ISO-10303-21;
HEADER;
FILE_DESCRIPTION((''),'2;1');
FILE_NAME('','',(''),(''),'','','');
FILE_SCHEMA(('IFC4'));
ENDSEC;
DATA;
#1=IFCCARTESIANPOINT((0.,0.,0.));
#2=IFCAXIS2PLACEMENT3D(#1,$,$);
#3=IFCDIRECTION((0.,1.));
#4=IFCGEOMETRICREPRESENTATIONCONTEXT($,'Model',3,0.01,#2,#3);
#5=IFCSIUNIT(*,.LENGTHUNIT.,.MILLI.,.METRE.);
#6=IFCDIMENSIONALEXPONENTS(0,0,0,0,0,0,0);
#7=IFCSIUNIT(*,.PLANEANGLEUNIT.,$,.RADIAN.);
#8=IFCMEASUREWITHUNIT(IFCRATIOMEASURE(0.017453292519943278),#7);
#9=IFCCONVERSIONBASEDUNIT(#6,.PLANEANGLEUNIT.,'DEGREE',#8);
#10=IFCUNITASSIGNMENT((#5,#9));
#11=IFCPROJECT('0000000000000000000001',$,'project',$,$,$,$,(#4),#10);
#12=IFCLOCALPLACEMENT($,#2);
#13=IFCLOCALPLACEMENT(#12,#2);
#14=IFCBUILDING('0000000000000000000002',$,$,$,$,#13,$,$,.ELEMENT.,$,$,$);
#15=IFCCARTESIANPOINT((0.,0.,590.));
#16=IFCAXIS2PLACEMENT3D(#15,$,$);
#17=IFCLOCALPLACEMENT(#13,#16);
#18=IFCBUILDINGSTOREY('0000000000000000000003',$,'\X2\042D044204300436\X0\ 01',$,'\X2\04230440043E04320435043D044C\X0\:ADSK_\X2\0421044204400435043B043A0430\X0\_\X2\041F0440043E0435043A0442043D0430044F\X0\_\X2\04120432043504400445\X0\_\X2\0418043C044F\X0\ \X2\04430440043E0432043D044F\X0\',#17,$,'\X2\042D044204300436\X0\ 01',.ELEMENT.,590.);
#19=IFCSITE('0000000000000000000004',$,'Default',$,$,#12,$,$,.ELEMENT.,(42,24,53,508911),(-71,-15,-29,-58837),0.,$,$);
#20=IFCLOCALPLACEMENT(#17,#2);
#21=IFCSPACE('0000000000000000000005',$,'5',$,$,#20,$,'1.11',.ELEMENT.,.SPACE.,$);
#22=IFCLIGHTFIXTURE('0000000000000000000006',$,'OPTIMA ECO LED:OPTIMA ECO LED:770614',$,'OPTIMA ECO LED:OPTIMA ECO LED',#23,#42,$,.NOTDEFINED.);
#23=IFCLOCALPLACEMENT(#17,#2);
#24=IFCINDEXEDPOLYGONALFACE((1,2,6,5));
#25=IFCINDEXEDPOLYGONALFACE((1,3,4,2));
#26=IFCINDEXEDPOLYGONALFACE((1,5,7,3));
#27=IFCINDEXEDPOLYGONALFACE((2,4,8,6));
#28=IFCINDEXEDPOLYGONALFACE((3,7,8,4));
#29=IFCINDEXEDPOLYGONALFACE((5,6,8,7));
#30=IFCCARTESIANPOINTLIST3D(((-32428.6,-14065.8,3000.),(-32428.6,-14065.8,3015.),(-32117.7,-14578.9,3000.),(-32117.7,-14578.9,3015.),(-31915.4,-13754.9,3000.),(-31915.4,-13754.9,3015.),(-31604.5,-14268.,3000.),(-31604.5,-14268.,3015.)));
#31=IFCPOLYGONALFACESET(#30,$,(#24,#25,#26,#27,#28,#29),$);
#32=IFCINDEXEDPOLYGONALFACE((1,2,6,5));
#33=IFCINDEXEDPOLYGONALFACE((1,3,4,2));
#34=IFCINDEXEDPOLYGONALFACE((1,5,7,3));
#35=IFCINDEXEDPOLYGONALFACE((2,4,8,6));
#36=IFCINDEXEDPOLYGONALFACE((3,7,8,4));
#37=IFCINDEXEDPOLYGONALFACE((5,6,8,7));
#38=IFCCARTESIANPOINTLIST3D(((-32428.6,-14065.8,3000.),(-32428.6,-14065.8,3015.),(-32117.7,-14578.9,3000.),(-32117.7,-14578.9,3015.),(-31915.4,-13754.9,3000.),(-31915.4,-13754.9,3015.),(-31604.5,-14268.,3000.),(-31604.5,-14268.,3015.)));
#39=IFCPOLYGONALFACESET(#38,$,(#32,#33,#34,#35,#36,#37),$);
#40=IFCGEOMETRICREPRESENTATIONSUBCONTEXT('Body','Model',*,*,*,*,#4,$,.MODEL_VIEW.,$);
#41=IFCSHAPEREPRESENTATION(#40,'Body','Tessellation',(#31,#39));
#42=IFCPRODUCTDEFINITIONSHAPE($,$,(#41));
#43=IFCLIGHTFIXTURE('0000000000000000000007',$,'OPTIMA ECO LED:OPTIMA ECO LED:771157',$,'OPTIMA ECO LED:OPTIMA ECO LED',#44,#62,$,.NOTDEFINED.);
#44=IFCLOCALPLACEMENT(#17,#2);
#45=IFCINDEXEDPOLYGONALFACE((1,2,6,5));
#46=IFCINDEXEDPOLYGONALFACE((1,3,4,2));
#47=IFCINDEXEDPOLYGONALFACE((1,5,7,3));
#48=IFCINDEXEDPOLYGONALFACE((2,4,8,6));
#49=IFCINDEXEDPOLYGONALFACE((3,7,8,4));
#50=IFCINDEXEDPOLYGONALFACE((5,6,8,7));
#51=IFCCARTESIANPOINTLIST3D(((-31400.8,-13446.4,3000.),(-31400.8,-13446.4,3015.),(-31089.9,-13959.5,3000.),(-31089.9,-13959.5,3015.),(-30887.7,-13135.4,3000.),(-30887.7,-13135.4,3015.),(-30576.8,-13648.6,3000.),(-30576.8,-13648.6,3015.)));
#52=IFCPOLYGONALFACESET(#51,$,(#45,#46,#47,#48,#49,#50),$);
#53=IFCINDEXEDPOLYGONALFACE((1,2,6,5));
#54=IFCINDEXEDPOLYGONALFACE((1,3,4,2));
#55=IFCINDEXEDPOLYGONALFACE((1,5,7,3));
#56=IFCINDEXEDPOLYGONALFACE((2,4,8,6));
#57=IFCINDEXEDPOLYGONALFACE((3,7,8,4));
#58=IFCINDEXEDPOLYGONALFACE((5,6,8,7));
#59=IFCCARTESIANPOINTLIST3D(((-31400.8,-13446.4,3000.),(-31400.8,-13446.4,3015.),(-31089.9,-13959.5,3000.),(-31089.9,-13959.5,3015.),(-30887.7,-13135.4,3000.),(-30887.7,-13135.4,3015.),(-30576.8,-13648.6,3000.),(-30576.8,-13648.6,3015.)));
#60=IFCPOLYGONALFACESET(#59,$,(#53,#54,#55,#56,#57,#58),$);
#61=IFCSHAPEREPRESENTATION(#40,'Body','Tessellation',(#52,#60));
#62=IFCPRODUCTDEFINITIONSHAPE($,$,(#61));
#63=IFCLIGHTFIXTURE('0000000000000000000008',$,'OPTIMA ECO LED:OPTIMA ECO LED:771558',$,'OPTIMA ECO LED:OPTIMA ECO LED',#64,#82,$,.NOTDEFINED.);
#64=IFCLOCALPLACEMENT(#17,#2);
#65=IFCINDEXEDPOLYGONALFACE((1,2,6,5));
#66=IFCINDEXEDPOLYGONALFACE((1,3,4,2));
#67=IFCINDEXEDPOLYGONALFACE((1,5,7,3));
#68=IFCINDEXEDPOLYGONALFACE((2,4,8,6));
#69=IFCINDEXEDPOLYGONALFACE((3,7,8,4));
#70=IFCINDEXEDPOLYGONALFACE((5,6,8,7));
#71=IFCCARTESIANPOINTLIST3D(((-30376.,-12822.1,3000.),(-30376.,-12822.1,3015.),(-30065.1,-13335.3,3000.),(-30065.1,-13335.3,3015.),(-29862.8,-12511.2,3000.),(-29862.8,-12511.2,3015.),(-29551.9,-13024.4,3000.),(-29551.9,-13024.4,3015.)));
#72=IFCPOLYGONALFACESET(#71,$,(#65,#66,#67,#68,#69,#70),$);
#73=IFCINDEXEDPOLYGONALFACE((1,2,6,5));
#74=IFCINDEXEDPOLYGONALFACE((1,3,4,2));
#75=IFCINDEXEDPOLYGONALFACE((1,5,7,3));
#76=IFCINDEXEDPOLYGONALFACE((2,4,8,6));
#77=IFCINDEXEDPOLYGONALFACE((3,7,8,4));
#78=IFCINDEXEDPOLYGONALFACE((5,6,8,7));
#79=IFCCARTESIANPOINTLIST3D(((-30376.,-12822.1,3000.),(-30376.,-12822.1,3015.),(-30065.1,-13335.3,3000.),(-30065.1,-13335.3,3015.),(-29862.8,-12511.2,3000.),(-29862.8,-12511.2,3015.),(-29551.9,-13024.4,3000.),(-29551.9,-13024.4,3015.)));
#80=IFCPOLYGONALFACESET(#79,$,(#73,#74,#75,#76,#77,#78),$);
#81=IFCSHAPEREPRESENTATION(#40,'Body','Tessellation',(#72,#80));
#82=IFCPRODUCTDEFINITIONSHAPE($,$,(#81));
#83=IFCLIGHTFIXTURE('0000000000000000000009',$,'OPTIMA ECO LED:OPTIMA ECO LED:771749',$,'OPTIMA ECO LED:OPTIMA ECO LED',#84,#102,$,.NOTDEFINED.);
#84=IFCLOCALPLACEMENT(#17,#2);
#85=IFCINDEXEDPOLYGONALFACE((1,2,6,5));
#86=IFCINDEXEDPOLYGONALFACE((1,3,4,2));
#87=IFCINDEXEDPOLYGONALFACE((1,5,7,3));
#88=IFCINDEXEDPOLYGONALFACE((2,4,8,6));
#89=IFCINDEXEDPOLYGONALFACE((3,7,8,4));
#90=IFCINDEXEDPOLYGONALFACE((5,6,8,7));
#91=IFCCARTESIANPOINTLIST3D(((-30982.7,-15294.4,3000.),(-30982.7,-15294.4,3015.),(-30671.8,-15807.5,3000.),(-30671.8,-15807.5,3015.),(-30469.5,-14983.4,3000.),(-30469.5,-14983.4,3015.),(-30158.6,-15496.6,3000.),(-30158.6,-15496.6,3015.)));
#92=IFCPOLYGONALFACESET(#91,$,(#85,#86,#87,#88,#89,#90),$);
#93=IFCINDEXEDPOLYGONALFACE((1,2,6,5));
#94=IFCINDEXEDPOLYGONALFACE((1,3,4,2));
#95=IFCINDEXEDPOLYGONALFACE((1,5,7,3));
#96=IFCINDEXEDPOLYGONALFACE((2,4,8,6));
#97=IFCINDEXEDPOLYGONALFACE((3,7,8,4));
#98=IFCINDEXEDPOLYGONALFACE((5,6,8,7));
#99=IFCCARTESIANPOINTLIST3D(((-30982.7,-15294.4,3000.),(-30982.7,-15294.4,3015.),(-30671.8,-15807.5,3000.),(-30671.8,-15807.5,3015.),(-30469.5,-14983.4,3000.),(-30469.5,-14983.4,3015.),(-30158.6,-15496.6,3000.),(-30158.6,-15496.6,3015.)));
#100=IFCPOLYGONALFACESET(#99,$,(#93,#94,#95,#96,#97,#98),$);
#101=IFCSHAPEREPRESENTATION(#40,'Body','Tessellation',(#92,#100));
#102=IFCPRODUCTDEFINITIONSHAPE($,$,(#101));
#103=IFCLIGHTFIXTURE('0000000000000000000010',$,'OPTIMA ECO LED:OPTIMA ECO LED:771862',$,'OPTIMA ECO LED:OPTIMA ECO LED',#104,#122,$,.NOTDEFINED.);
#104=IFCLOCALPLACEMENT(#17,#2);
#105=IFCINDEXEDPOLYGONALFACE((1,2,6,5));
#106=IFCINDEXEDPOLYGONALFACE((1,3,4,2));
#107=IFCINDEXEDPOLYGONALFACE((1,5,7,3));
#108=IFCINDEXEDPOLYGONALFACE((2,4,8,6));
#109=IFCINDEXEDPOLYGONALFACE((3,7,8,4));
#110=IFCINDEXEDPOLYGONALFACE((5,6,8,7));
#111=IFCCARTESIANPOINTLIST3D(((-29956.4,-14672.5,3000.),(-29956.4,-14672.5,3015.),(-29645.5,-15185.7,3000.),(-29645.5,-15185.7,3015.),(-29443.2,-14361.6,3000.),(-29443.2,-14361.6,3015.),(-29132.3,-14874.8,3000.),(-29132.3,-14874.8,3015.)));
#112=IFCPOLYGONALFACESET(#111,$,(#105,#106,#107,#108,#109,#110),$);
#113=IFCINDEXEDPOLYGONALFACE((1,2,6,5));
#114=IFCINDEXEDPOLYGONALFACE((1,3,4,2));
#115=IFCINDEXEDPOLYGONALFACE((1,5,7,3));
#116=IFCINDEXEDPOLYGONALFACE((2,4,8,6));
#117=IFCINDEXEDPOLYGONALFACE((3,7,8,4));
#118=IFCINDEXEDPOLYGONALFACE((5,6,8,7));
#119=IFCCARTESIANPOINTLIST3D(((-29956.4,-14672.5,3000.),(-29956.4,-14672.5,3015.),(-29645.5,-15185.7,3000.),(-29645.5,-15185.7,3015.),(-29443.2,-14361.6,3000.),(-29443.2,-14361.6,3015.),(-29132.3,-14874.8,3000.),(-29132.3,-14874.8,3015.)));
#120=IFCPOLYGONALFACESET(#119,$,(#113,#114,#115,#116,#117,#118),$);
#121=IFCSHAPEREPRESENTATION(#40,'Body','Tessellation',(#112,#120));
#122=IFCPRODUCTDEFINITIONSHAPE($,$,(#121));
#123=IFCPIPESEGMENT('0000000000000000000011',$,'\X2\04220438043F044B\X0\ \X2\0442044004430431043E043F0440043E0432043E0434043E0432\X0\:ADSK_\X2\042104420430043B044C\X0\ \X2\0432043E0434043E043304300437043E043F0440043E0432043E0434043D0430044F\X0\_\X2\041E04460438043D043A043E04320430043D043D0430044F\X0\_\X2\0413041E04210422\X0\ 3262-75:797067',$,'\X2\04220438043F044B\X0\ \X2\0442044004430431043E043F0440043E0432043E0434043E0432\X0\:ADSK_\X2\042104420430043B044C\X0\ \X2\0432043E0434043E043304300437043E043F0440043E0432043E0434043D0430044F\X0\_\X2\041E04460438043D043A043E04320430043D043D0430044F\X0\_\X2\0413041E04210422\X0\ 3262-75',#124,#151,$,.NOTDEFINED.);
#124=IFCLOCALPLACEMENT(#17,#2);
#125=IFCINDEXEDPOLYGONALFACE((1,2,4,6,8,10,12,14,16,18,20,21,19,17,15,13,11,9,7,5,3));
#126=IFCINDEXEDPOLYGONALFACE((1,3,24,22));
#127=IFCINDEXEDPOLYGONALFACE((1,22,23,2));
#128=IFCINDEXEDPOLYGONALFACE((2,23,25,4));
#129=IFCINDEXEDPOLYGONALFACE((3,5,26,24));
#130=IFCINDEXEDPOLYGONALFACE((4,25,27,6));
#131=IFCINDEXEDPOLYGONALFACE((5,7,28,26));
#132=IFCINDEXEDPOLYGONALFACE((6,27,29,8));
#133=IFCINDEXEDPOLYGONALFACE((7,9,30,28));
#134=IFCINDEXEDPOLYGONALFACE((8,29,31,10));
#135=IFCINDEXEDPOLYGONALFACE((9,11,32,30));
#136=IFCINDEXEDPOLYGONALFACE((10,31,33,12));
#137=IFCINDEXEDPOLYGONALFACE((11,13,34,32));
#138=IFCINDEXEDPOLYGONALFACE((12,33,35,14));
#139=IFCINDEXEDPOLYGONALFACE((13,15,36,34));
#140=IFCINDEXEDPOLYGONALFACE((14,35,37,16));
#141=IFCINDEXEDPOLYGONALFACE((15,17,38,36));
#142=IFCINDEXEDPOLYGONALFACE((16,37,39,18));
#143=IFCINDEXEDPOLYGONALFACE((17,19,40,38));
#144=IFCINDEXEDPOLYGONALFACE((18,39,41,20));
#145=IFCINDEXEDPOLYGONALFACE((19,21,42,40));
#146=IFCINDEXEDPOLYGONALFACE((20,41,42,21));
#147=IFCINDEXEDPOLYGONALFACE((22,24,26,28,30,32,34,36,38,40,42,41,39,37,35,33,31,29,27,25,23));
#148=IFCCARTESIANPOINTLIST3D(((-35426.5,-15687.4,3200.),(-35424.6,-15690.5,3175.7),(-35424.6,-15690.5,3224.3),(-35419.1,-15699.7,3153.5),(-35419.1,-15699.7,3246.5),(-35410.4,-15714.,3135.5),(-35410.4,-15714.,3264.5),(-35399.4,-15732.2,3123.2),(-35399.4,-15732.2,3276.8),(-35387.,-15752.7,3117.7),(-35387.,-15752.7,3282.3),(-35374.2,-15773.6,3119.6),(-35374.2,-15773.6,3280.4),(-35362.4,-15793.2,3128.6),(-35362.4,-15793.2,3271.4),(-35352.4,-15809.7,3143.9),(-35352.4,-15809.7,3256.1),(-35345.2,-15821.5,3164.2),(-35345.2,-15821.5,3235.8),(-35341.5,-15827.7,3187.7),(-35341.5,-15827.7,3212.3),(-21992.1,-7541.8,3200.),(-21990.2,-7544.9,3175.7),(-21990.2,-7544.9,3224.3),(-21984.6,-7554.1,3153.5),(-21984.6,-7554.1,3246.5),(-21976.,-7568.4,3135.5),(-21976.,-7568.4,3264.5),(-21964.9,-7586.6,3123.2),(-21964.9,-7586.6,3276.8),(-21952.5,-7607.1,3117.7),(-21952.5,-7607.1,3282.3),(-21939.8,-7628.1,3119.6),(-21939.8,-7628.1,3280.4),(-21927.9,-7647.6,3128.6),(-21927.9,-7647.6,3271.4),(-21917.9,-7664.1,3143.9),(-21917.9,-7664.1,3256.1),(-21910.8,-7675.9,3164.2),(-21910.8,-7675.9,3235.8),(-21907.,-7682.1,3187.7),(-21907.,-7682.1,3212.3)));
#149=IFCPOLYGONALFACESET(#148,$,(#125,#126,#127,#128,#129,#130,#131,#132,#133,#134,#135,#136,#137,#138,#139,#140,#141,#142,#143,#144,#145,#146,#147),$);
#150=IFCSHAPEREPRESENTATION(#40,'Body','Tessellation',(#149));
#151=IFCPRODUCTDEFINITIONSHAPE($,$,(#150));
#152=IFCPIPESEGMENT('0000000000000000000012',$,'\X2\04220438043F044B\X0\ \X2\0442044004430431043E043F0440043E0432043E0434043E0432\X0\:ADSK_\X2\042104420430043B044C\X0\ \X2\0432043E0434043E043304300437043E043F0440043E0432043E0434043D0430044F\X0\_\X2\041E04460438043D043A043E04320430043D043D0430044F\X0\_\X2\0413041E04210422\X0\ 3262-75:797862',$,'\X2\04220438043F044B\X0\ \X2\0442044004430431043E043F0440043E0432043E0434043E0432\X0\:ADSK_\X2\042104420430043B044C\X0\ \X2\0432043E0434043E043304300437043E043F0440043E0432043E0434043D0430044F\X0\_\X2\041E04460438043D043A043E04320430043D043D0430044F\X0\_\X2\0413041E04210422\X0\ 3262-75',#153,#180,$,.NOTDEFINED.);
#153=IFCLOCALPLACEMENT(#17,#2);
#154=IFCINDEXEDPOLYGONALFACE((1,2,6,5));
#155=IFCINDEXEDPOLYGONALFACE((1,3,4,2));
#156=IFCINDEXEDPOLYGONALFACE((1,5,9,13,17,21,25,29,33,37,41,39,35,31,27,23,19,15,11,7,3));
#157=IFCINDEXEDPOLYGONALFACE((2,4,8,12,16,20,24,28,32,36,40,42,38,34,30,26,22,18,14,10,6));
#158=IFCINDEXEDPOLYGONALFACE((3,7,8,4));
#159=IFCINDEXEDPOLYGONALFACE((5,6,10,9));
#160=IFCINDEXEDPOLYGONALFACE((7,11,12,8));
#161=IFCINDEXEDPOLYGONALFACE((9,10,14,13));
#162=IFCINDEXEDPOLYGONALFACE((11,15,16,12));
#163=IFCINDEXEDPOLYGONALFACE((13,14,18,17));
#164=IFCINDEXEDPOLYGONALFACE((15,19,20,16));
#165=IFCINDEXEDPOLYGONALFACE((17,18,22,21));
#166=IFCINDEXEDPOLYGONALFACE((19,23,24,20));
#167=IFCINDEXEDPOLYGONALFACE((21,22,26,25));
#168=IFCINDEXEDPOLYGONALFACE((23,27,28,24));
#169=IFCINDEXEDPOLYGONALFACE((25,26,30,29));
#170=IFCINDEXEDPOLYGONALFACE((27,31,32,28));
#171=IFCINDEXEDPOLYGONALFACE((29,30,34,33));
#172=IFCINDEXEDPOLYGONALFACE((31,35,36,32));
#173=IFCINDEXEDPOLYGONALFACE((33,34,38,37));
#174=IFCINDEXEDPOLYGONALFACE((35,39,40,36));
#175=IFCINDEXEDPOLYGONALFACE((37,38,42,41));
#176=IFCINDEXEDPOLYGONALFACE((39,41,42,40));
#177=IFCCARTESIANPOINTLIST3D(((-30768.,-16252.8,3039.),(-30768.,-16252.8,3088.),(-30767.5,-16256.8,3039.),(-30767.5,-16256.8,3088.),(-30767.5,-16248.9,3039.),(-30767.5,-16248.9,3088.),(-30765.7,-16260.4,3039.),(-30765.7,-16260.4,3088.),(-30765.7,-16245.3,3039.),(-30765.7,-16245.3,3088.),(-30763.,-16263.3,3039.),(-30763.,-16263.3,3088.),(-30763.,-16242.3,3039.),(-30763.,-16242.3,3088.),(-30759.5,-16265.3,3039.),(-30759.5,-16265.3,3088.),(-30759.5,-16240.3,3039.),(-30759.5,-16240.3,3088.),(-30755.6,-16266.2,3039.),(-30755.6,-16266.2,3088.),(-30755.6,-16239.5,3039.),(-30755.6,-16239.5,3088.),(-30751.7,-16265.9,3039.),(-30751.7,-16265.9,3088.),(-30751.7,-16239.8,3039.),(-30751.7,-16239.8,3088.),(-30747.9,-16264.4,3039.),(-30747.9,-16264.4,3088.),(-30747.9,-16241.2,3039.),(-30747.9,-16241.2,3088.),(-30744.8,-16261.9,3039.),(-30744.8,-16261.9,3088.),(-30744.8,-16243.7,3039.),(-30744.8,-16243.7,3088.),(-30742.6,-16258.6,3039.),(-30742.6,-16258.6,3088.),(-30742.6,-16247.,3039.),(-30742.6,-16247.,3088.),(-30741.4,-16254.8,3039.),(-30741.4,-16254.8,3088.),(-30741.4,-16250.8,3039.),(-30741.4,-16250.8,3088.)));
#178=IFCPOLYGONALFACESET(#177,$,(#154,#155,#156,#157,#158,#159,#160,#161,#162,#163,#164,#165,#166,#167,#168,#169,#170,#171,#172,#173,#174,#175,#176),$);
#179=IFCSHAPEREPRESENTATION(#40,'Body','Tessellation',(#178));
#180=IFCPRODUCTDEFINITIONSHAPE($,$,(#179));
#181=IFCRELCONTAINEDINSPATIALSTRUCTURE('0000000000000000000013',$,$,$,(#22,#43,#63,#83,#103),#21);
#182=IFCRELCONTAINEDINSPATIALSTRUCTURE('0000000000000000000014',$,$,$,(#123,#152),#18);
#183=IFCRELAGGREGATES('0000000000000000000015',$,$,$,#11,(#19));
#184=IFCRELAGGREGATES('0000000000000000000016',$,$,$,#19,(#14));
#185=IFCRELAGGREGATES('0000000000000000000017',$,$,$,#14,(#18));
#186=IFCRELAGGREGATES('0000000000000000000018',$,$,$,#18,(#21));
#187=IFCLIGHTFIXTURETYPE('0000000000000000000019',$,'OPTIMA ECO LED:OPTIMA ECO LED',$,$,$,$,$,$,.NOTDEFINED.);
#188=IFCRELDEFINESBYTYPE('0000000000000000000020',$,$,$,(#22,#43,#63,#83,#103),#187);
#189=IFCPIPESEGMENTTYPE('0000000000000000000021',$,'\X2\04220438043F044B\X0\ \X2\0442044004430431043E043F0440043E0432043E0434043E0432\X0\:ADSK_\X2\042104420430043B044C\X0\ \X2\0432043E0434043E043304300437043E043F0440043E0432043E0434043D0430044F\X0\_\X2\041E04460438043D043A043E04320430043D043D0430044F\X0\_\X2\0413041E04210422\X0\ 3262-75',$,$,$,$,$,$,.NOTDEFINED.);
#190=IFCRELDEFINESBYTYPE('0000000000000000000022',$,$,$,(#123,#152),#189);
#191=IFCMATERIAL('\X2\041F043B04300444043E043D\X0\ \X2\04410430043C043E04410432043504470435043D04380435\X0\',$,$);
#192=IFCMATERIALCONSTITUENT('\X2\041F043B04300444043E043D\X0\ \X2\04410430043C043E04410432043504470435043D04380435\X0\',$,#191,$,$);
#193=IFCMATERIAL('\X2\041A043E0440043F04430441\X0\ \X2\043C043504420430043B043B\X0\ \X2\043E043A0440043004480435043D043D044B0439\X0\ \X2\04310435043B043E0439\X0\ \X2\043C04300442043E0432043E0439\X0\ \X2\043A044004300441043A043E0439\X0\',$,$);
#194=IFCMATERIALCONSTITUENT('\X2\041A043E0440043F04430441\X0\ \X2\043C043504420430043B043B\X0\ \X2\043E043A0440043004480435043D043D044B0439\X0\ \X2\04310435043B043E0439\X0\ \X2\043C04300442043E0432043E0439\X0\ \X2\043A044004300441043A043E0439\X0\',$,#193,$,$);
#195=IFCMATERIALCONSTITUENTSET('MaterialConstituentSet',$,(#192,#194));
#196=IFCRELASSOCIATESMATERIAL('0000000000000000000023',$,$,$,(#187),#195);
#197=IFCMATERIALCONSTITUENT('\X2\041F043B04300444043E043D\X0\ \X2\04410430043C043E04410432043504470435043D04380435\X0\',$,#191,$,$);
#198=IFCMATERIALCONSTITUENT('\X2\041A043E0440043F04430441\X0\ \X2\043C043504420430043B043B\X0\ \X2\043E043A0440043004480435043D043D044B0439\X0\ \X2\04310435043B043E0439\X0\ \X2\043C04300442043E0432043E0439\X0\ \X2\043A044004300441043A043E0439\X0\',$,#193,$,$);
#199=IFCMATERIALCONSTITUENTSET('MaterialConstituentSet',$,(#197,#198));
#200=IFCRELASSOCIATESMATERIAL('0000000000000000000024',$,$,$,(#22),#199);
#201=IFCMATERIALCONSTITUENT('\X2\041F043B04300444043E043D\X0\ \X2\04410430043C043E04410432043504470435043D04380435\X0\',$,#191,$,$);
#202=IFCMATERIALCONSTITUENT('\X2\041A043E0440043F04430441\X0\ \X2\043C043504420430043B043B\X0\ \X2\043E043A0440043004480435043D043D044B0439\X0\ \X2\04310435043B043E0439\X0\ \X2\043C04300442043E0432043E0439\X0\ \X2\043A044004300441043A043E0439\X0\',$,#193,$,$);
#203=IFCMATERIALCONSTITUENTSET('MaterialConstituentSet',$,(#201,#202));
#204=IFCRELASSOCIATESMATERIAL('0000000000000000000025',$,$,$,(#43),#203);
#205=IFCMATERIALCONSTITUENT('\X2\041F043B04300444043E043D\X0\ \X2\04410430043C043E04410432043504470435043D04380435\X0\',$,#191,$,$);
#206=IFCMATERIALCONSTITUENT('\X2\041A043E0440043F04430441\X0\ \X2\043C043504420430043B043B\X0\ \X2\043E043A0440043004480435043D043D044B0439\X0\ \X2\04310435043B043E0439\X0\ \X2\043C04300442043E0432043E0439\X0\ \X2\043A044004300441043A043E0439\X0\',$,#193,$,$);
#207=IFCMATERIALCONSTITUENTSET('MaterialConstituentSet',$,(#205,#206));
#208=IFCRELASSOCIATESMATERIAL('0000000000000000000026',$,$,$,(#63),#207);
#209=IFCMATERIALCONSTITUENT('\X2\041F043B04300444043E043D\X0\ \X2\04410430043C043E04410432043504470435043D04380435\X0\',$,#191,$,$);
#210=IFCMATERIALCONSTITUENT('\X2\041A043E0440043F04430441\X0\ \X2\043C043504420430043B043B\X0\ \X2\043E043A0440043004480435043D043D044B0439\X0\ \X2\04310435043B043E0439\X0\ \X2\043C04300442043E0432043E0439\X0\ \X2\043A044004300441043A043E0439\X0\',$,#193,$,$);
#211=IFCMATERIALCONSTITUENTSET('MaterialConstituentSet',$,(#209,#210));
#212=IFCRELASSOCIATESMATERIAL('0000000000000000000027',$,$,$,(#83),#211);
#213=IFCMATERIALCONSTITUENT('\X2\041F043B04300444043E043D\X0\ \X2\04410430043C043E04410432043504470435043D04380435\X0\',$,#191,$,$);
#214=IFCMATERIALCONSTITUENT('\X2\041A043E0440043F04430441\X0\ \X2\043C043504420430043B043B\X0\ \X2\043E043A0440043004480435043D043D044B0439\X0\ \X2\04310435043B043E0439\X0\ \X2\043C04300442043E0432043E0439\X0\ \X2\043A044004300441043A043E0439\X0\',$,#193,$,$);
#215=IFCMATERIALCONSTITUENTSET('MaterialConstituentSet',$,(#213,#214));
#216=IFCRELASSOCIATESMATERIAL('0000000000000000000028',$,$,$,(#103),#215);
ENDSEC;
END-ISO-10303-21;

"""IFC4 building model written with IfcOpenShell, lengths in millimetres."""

from ifc_helpers import new_model, entity, si_unit, converted_unit, direction, frame, frame_2d, origin, origin_2d_with_axis, place, context, subcontext, project, spatial, rectangle, circle, extrude, source, transform, mapped, material, constituent, constituent_set, type_object, type_shapes, element, save


model = new_model("IFC4")

# Units and contexts
model_context = context("Model", 3, precision=0.01, world=origin(), true_north=direction((0.0, 1.0)))
body_context = subcontext(model_context, "Body", "Model", "MODEL_VIEW")
ifc_project = project(units=[si_unit("LENGTHUNIT", "METRE", prefix="MILLI"), converted_unit("PLANEANGLEUNIT", "DEGREE", entity("IfcRatioMeasure", 0.017453292519943278), si_unit("PLANEANGLEUNIT", "RADIAN"), dimensions=[0, 0, 0, 0, 0, 0, 0])], contexts=[model_context])

# Site, building, storey
site_placement = place(None, origin())
site = spatial("IfcSite", under=ifc_project, at=site_placement, Name="Default", CompositionType="ELEMENT", RefLatitude=(42, 24, 53, 508911), RefLongitude=(-71, -15, -29, -58837), RefElevation=0.0)
building_placement = place(site_placement, origin())
building = spatial("IfcBuilding", under=site, at=building_placement, CompositionType="ELEMENT")
storey_placement = place(building_placement, frame((0.0, 0.0, 590.0)))
storey = spatial("IfcBuildingStorey", under=building, at=storey_placement, Name="Этаж 01", ObjectType="Уровень:ADSK_Стрелка_Проектная_Вверх_Имя уровня", LongName="Этаж 01", CompositionType="ELEMENT", Elevation=590.0)

# Shared definitions
space_1_placement = place(storey_placement, origin())
space_1 = spatial("IfcSpace", under=storey, at=space_1_placement, Name="5", LongName="1.11", CompositionType="ELEMENT", PredefinedType="SPACE")

# Light fixtures
ifc_material_1 = material(Name="Плафон самосвечение")
ifc_constituent_1 = constituent(ifc_material_1, Name="Плафон самосвечение")
ifc_material_2 = material(Name="Корпус металл окрашенный белой матовой краской")
ifc_constituent_2 = constituent(ifc_material_2, Name="Корпус металл окрашенный белой матовой краской")
ifc_constituent_set_1 = constituent_set(constituents=[ifc_constituent_1, ifc_constituent_2], Name="MaterialConstituentSet")
ifc_constituent_3 = constituent(ifc_material_1, Name="Плафон самосвечение")
ifc_constituent_4 = constituent(ifc_material_2, Name="Корпус металл окрашенный белой матовой краской")
ifc_constituent_set_2 = constituent_set(constituents=[ifc_constituent_3, ifc_constituent_4], Name="MaterialConstituentSet")
light_fixture_type = type_object("IfcLightFixtureType", Name="OPTIMA ECO LED:OPTIMA ECO LED", PredefinedType="NOTDEFINED", material=ifc_constituent_set_2)
shared_shape_1 = source(origin(), body_context, "Body", "SweptSolid", [
    extrude(rectangle(XDim=600.0, YDim=600.0, at=frame_2d((0.0, 0.0), x_axis=(1.0, 0.0))), frame((0.0, 0.0, -15.0)), (0.0, 0.0, 1.0), 15.0),
    extrude(rectangle(XDim=600.0, YDim=600.0, at=frame_2d((0.0, 0.0), x_axis=(1.0, 0.0))), frame((0.0, 0.0, -15.0)), (0.0, 0.0, 1.0), 15.0),
])
type_shapes(light_fixture_type, [shared_shape_1])
light_fixture_1_placement = place(space_1_placement, frame((-32016.6, -14166.9, 3000.0), z_axis=(0.0, 0.0, -1.0), x_axis=(0.855267, 0.518188, 0.0)))
element("IfcLightFixture", 1, at=light_fixture_1_placement, inside=space_1, type_object=light_fixture_type, material=ifc_constituent_set_1, Name="OPTIMA ECO LED:OPTIMA ECO LED:770614", ObjectType="OPTIMA ECO LED:OPTIMA ECO LED", PredefinedType="NOTDEFINED", context=body_context, shape_type="MappedRepresentation", body=[
    mapped(shared_shape_1, transform((0.0, 0.0, 0.0), scale=1.0)),
])
ifc_constituent_5 = constituent(ifc_material_1, Name="Плафон самосвечение")
ifc_constituent_6 = constituent(ifc_material_2, Name="Корпус металл окрашенный белой матовой краской")
ifc_constituent_set_3 = constituent_set(constituents=[ifc_constituent_5, ifc_constituent_6], Name="MaterialConstituentSet")
light_fixture_2_placement = place(space_1_placement, frame((-30988.8, -13547.5, 3000.0), z_axis=(0.0, 0.0, -1.0), x_axis=(0.518188, -0.855267, 0.0)))
element("IfcLightFixture", 2, at=light_fixture_2_placement, inside=space_1, type_object=light_fixture_type, material=ifc_constituent_set_3, Name="OPTIMA ECO LED:OPTIMA ECO LED:771157", ObjectType="OPTIMA ECO LED:OPTIMA ECO LED", PredefinedType="NOTDEFINED", context=body_context, shape_type="MappedRepresentation", body=[
    mapped(shared_shape_1, transform((0.0, 0.0, 0.0), scale=1.0)),
])
ifc_constituent_7 = constituent(ifc_material_1, Name="Плафон самосвечение")
ifc_constituent_8 = constituent(ifc_material_2, Name="Корпус металл окрашенный белой матовой краской")
ifc_constituent_set_4 = constituent_set(constituents=[ifc_constituent_7, ifc_constituent_8], Name="MaterialConstituentSet")
light_fixture_3_placement = place(space_1_placement, frame((-29963.9, -12923.3, 3000.0), z_axis=(0.0, 0.0, -1.0), x_axis=(0.518188, -0.855267, 0.0)))
element("IfcLightFixture", 3, at=light_fixture_3_placement, inside=space_1, type_object=light_fixture_type, material=ifc_constituent_set_4, Name="OPTIMA ECO LED:OPTIMA ECO LED:771558", ObjectType="OPTIMA ECO LED:OPTIMA ECO LED", PredefinedType="NOTDEFINED", context=body_context, shape_type="MappedRepresentation", body=[
    mapped(shared_shape_1, transform((0.0, 0.0, 0.0), scale=1.0)),
])
ifc_constituent_9 = constituent(ifc_material_1, Name="Плафон самосвечение")
ifc_constituent_10 = constituent(ifc_material_2, Name="Корпус металл окрашенный белой матовой краской")
ifc_constituent_set_5 = constituent_set(constituents=[ifc_constituent_9, ifc_constituent_10], Name="MaterialConstituentSet")
light_fixture_4_placement = place(space_1_placement, frame((-30570.7, -15395.5, 3000.0), z_axis=(0.0, 0.0, -1.0), x_axis=(0.855267, 0.518188, 0.0)))
element("IfcLightFixture", 4, at=light_fixture_4_placement, inside=space_1, type_object=light_fixture_type, material=ifc_constituent_set_5, Name="OPTIMA ECO LED:OPTIMA ECO LED:771749", ObjectType="OPTIMA ECO LED:OPTIMA ECO LED", PredefinedType="NOTDEFINED", context=body_context, shape_type="MappedRepresentation", body=[
    mapped(shared_shape_1, transform((0.0, 0.0, 0.0), scale=1.0)),
])
ifc_constituent_11 = constituent(ifc_material_1, Name="Плафон самосвечение")
ifc_constituent_12 = constituent(ifc_material_2, Name="Корпус металл окрашенный белой матовой краской")
ifc_constituent_set_6 = constituent_set(constituents=[ifc_constituent_11, ifc_constituent_12], Name="MaterialConstituentSet")
light_fixture_5_placement = place(space_1_placement, frame((-29544.4, -14773.6, 3000.0), z_axis=(0.0, 0.0, -1.0), x_axis=(-0.518188, 0.855267, 0.0)))
element("IfcLightFixture", 5, at=light_fixture_5_placement, inside=space_1, type_object=light_fixture_type, material=ifc_constituent_set_6, Name="OPTIMA ECO LED:OPTIMA ECO LED:771862", ObjectType="OPTIMA ECO LED:OPTIMA ECO LED", PredefinedType="NOTDEFINED", context=body_context, shape_type="MappedRepresentation", body=[
    mapped(shared_shape_1, transform((0.0, 0.0, 0.0), scale=1.0)),
])

# Pipe segments
pipe_segment_type = type_object("IfcPipeSegmentType", Name="Типы трубопроводов:ADSK_Сталь водогазопроводная_Оцинкованная_ГОСТ 3262-75", PredefinedType="NOTDEFINED")
pipe_segment_1_placement = place(storey_placement, frame((-35428.1, -15830.1, 3115.9)))
element("IfcPipeSegment", 6, at=pipe_segment_1_placement, inside=storey, type_object=pipe_segment_type, Name="Типы трубопроводов:ADSK_Сталь водогазопроводная_Оцинкованная_ГОСТ 3262-75:797067", ObjectType="Типы трубопроводов:ADSK_Сталь водогазопроводная_Оцинкованная_ГОСТ 3262-75", PredefinedType="NOTDEFINED", context=body_context, shape_type="SweptSolid", body=[
    extrude(circle(Radius=82.5, at=origin_2d_with_axis()), frame((44.4, 72.1, 84.1), z_axis=(0.855099, 0.518464, 0.0), x_axis=(-0.518464, 0.855099, 0.0)), (0.0, 0.0, 1.0), 15711.0),
])
pipe_segment_2_placement = place(storey_placement, frame((-30769.6, -16267.8, 3088.0)))
element("IfcPipeSegment", 7, at=pipe_segment_2_placement, inside=storey, type_object=pipe_segment_type, Name="Типы трубопроводов:ADSK_Сталь водогазопроводная_Оцинкованная_ГОСТ 3262-75:797862", ObjectType="Типы трубопроводов:ADSK_Сталь водогазопроводная_Оцинкованная_ГОСТ 3262-75", PredefinedType="NOTDEFINED", context=body_context, shape_type="SweptSolid", body=[
    extrude(circle(Radius=13.4, at=origin_2d_with_axis()), frame((15.0, 15.0, -49.0), z_axis=(0.0, 0.0, 1.0), x_axis=(-1.0, 0.0, 0.0)), (0.0, 0.0, 1.0), 49.0),
])

save(model, "model.ifc")
